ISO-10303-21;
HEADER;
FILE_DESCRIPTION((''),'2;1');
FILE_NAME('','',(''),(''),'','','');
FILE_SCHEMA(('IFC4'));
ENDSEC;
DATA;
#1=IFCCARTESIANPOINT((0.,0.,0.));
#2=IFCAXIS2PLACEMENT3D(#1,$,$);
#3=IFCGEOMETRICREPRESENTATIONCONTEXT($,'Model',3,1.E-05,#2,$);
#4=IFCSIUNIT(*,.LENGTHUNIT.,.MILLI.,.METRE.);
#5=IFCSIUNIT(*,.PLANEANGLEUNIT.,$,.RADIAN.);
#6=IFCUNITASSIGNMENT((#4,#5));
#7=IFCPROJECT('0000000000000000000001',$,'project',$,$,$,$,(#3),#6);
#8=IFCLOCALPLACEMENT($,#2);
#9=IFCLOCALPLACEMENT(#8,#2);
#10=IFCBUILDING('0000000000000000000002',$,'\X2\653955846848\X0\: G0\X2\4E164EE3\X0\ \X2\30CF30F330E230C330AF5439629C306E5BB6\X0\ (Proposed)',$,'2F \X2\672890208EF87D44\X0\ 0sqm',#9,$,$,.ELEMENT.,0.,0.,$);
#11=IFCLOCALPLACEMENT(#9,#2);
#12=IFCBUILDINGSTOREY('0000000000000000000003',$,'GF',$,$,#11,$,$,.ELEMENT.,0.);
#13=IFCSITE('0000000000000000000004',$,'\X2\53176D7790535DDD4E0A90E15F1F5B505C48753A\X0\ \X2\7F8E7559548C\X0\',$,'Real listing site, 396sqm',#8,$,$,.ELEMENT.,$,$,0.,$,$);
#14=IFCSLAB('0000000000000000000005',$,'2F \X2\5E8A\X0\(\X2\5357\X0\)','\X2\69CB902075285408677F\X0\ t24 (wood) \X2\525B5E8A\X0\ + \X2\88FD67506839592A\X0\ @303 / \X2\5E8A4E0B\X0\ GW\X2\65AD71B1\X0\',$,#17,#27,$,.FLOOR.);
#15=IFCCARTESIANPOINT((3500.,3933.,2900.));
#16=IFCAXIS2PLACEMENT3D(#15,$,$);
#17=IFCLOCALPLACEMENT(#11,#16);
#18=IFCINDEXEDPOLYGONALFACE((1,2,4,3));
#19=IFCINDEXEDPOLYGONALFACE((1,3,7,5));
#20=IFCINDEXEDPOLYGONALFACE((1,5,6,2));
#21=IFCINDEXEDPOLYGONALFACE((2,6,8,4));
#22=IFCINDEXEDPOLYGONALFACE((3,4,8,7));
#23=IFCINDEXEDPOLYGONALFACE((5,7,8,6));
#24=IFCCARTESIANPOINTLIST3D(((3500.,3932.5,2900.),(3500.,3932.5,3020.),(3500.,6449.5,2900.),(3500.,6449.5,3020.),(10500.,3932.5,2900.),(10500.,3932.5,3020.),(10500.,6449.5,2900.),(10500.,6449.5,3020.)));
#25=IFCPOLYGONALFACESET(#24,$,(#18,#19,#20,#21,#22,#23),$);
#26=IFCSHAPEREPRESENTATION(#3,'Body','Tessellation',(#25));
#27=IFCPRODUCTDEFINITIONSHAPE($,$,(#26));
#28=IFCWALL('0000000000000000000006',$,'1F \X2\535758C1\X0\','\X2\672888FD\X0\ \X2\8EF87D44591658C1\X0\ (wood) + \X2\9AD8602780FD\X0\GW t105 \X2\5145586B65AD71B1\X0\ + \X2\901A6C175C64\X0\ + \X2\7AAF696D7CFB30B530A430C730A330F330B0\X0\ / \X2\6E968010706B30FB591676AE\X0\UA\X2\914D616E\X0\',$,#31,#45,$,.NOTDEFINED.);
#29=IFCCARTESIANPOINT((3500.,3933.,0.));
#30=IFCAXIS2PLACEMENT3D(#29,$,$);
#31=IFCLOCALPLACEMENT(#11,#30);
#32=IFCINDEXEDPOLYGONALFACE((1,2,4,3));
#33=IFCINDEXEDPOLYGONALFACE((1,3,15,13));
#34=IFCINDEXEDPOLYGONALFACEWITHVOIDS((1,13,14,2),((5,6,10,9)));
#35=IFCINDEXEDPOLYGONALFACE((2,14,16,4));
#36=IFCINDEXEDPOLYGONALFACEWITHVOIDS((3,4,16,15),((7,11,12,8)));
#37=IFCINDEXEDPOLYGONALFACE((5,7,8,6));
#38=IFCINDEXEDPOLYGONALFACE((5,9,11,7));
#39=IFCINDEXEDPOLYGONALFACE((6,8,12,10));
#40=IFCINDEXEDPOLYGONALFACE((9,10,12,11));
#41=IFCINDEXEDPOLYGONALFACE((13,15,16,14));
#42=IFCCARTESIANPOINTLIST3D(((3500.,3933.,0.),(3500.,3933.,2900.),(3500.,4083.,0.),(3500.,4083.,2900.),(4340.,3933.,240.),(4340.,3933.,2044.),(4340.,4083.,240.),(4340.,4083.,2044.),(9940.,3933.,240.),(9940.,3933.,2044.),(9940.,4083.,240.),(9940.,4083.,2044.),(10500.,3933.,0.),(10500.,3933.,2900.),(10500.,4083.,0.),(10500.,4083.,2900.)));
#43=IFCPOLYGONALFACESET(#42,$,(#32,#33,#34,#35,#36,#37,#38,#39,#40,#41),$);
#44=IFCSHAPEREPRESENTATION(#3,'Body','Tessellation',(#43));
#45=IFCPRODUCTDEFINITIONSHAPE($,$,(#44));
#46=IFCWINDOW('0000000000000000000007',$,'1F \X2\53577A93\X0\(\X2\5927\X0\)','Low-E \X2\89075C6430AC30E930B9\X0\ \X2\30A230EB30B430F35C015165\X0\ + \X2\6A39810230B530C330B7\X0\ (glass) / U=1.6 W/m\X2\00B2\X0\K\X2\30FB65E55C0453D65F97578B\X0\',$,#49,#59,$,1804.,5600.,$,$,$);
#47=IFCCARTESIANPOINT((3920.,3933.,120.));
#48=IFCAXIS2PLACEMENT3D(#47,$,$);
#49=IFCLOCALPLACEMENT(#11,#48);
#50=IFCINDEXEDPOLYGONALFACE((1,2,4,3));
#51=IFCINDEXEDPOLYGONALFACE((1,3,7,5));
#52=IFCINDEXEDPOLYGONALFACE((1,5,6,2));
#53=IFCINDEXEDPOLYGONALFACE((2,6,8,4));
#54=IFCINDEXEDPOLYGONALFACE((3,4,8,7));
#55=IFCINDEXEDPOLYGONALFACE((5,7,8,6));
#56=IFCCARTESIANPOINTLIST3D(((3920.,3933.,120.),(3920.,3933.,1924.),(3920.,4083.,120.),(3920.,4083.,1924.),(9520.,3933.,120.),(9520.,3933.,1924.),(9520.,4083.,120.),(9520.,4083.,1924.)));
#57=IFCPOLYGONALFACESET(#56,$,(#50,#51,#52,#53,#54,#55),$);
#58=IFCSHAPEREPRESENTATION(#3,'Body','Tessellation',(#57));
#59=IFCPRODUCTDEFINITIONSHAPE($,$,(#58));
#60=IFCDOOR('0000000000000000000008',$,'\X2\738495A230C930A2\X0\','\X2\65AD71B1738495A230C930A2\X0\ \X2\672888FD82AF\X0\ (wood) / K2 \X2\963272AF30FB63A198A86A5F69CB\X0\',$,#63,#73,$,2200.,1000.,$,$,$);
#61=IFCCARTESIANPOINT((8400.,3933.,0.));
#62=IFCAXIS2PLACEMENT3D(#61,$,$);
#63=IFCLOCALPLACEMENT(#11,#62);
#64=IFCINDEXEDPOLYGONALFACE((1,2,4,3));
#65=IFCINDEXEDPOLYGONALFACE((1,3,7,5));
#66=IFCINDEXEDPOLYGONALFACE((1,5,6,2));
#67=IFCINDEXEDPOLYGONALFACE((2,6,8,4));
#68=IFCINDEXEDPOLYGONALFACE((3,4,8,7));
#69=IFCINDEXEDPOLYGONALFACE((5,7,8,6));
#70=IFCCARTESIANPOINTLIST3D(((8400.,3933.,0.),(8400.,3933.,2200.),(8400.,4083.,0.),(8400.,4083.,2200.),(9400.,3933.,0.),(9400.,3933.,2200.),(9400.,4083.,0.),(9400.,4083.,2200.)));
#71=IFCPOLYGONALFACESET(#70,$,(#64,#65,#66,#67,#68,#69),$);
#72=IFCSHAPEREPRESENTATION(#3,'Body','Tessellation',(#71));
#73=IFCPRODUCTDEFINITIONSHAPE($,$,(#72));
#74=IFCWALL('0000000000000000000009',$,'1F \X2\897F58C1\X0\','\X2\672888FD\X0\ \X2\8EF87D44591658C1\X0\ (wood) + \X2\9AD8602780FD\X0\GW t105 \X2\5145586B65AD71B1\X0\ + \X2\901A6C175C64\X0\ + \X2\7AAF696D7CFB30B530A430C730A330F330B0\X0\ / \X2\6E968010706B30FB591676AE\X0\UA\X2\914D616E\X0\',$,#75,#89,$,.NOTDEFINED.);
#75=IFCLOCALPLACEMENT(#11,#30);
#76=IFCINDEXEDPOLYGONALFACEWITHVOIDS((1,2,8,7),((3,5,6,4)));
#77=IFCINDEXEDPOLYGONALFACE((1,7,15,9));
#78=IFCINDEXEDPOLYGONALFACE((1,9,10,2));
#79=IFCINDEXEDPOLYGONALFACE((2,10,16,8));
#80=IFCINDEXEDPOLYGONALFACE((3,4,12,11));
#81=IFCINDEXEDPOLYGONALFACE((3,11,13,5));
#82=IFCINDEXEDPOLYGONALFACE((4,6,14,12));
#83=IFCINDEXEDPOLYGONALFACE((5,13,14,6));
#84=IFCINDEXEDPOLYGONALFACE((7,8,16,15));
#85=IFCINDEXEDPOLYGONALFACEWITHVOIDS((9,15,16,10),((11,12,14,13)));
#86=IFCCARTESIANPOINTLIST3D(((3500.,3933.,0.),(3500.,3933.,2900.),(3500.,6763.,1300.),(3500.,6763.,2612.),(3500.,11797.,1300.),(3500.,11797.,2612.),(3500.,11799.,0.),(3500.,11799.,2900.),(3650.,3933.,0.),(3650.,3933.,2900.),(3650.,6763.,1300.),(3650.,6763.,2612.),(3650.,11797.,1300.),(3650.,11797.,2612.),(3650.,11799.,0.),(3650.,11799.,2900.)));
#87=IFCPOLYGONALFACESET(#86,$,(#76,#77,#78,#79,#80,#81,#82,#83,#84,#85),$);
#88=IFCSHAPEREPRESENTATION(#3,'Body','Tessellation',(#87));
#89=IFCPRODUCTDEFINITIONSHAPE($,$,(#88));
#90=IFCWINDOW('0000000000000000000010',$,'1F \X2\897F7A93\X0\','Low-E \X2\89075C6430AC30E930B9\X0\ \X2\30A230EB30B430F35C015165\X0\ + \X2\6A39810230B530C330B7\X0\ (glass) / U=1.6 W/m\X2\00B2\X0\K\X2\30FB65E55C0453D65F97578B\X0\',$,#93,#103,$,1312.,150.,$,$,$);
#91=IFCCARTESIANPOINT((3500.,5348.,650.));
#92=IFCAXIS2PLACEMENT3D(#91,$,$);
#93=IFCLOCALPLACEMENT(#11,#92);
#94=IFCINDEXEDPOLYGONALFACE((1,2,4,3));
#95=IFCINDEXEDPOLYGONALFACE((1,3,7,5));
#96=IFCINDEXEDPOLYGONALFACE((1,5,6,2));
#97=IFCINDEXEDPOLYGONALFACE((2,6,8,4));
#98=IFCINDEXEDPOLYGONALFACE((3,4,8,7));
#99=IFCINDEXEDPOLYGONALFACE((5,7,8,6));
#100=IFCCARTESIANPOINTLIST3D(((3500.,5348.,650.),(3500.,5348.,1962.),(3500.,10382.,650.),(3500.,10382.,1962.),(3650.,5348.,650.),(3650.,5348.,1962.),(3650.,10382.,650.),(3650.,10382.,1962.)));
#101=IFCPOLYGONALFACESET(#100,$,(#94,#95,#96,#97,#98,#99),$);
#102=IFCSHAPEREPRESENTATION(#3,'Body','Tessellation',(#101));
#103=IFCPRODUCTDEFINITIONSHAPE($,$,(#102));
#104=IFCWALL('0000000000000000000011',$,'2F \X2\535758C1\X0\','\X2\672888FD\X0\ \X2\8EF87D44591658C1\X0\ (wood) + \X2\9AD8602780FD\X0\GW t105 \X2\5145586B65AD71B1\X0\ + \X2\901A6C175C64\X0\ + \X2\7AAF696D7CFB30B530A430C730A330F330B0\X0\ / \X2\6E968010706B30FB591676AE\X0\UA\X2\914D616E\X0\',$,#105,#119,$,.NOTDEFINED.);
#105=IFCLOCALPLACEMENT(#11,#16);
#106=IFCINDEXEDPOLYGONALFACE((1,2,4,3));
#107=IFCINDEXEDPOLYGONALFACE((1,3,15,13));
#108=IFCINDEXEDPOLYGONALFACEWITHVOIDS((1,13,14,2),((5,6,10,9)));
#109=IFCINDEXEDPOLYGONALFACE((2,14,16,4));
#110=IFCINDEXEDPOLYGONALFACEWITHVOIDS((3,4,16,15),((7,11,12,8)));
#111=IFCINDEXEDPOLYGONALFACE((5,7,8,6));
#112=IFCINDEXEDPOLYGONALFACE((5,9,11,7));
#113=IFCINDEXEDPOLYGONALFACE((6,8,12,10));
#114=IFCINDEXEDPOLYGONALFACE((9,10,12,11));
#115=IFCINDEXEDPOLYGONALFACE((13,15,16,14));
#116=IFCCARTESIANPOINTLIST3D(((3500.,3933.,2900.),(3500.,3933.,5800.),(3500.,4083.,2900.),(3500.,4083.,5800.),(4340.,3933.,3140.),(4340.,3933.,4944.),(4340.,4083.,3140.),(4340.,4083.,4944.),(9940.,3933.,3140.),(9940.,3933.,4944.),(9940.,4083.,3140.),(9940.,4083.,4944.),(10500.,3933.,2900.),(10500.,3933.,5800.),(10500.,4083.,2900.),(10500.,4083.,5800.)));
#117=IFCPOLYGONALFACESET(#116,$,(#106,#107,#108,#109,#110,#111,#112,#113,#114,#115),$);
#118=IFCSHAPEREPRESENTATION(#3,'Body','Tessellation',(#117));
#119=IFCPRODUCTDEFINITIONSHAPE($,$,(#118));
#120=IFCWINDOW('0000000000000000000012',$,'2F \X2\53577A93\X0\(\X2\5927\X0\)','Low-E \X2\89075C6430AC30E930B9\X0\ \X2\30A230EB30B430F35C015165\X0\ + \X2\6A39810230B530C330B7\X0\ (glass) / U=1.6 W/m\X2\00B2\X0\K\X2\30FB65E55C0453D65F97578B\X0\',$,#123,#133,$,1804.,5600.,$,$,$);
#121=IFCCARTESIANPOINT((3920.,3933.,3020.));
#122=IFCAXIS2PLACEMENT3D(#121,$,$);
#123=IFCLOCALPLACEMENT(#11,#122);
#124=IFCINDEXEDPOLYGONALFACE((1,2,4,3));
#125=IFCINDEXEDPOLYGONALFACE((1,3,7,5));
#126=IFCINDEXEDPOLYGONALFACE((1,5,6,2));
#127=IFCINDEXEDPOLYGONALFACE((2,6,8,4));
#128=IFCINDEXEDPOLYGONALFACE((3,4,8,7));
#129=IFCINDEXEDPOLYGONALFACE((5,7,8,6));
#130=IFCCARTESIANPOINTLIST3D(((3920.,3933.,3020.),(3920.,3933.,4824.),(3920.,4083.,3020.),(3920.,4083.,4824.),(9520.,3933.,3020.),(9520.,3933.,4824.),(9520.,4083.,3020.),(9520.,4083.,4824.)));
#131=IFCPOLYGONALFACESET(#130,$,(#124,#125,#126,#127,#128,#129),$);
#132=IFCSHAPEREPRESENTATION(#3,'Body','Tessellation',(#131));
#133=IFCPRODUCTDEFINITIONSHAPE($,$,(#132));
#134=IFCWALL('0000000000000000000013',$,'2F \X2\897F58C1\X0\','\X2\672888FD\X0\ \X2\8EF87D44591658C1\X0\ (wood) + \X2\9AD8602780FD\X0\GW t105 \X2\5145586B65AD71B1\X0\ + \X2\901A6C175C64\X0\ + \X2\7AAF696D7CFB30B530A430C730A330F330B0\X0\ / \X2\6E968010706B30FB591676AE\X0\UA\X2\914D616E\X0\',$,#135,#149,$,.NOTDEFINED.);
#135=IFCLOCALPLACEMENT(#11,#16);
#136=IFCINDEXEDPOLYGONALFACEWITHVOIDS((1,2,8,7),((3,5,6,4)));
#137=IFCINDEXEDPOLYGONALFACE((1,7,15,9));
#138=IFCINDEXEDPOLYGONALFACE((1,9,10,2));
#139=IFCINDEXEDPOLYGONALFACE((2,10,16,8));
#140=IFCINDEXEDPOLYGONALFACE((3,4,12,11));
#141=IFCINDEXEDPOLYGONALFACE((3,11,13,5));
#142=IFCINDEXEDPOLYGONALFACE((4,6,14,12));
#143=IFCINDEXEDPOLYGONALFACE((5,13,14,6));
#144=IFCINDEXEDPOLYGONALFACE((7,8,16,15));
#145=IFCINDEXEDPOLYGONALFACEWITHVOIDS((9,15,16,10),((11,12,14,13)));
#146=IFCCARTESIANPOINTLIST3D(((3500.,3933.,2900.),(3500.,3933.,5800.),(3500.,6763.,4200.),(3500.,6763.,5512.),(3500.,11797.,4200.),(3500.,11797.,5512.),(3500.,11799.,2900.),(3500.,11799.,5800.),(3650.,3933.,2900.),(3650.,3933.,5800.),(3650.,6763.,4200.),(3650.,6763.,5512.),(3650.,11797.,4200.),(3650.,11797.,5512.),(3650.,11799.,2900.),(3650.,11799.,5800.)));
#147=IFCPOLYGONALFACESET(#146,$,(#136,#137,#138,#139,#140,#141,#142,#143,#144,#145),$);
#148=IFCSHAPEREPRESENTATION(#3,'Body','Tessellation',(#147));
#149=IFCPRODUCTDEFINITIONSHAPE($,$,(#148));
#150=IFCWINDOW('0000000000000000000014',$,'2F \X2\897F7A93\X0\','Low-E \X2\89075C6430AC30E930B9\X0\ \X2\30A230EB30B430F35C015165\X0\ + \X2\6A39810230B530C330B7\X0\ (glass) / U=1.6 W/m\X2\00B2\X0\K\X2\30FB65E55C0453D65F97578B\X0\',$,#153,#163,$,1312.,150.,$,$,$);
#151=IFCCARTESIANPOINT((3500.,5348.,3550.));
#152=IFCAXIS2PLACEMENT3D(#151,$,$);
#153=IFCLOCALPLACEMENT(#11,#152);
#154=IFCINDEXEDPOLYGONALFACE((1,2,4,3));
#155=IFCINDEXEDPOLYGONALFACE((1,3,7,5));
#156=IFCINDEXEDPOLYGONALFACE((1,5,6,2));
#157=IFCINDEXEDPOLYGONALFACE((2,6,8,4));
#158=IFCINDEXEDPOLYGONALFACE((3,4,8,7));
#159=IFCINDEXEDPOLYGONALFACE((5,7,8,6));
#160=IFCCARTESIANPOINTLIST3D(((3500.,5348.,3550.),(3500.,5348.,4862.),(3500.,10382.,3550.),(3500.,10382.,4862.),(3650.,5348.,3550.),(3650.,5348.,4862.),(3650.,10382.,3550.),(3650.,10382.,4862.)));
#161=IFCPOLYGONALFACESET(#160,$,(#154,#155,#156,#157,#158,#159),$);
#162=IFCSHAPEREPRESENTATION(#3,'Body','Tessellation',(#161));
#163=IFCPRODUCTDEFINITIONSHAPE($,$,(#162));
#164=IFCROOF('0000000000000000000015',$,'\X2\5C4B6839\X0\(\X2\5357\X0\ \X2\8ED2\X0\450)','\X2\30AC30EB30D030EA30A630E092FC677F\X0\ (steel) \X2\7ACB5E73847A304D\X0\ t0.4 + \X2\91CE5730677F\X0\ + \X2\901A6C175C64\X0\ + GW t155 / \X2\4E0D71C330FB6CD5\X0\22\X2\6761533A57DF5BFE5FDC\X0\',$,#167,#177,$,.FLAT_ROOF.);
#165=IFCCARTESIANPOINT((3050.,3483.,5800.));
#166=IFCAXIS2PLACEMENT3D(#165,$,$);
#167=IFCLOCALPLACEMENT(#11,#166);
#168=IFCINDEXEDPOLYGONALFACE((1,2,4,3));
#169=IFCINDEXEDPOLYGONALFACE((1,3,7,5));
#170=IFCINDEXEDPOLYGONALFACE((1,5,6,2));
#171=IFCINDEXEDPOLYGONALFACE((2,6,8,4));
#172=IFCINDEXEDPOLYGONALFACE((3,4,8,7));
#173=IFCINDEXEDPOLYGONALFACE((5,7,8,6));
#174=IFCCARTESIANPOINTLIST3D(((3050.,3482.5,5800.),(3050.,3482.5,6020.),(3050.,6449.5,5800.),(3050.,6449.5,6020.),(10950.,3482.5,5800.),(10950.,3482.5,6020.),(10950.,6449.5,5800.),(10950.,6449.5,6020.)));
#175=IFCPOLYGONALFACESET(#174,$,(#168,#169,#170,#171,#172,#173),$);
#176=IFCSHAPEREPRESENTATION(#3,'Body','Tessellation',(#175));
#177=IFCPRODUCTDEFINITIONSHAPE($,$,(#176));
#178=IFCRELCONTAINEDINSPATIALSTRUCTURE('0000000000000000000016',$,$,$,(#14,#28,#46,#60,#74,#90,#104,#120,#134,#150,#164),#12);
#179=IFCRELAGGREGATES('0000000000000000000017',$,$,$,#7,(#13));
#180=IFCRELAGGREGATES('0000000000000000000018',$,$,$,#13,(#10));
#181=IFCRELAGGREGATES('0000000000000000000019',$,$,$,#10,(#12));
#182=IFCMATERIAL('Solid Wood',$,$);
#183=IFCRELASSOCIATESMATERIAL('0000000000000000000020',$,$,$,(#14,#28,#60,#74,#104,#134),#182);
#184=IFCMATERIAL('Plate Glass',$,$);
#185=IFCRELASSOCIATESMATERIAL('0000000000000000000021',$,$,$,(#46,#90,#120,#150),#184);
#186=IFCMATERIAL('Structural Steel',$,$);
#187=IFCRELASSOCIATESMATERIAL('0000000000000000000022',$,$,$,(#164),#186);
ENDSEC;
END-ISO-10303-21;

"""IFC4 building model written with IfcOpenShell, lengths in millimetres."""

from ifc_helpers import new_model, si_unit, frame, frame_2d, origin, place, context, project, spatial, rectangle, extrude, material, element, fill, save


model = new_model("IFC4")

# Units and contexts
model_context = context("Model", 3, precision=1e-05, world=origin())
ifc_project = project(units=[si_unit("LENGTHUNIT", "METRE", prefix="MILLI"), si_unit("PLANEANGLEUNIT", "RADIAN")], contexts=[model_context])

# Site, building, storey
site_placement = place(None, origin())
site = spatial("IfcSite", under=ifc_project, at=site_placement, Name="北海道川上郡弟子屈町 美留和", ObjectType="Real listing site, 396sqm", CompositionType="ELEMENT", RefElevation=0.0)
building_placement = place(site_placement, origin())
building = spatial("IfcBuilding", under=site, at=building_placement, Name="改善案: G0世代 ハンモック吹抜の家 (Proposed)", ObjectType="2F 木造軸組 0sqm", CompositionType="ELEMENT", ElevationOfRefHeight=0.0, ElevationOfTerrain=0.0)
storey_placement = place(building_placement, origin())
storey = spatial("IfcBuildingStorey", under=building, at=storey_placement, Name="GF", CompositionType="ELEMENT", Elevation=0.0)

# Slab
ifc_material_1 = material(Name="Solid Wood")
slab_1_placement = place(storey_placement, frame((3500.0, 3933.0, 2900.0)))
element("IfcSlab", 1, at=slab_1_placement, inside=storey, material=ifc_material_1, Name="2F 床(南)", Description="構造用合板 t24 (wood) 剛床 + 製材根太 @303 / 床下 GW断熱", PredefinedType="FLOOR", context=model_context, shape_type="SweptSolid", body=[
    extrude(rectangle(XDim=7000.0, YDim=2517.0, at=frame_2d((3500.0, 1258.0))), frame((3500.0, 3933.0, 2900.0)), (0.0, 0.0, 1.0), 120.0),
])

# Wall, openings, window, door
wall_1_placement = place(storey_placement, frame((3500.0, 3933.0, 0.0)))
wall_1 = element("IfcWall", 2, at=wall_1_placement, inside=storey, material=ifc_material_1, Name="1F 南壁", Description="木製 軸組外壁 (wood) + 高性能GW t105 充填断熱 + 通気層 + 窯業系サイディング / 準耐火・外皮UA配慮", PredefinedType="NOTDEFINED", context=model_context, shape_type="SweptSolid", body=[
    extrude(rectangle(XDim=7000.0, YDim=150.0, at=frame_2d((3500.0, 75.0))), frame((3500.0, 3933.0, 0.0)), (0.0, 0.0, 1.0), 2900.0),
])
opening_1_placement = place(storey_placement, frame((3920.0, 3933.0, 120.0)))
opening_1 = element("IfcOpeningElement", 3, at=opening_1_placement, cuts=wall_1, PredefinedType="NOTDEFINED", context=model_context, shape_type="SweptSolid", body=[
    extrude(rectangle(XDim=5600.0, YDim=150.0, at=frame_2d((2800.0, 75.0))), frame((3920.0, 3933.0, 120.0)), (0.0, 0.0, 1.0), 1804.0),
])
opening_2_placement = place(storey_placement, frame((8400.0, 3933.0, 0.0)))
opening_2 = element("IfcOpeningElement", 4, at=opening_2_placement, cuts=wall_1, PredefinedType="NOTDEFINED", context=model_context, shape_type="SweptSolid", body=[
    extrude(rectangle(XDim=1000.0, YDim=150.0, at=frame_2d((500.0, 75.0))), frame((8400.0, 3933.0, 0.0)), (0.0, 0.0, 1.0), 2200.0),
])
ifc_material_2 = material(Name="Plate Glass")
window_1_placement = place(storey_placement, frame((3920.0, 3933.0, 120.0)))
window_1 = element("IfcWindow", 5, at=window_1_placement, inside=storey, material=ifc_material_2, Name="1F 南窓(大)", Description="Low-E 複層ガラス アルゴン封入 + 樹脂サッシ (glass) / U=1.6 W/m²K・日射取得型", OverallHeight=1804.0, OverallWidth=5600.0, context=model_context, shape_type="SweptSolid", body=[
    extrude(rectangle(XDim=5600.0, YDim=150.0, at=frame_2d((2800.0, 75.0))), frame((3920.0, 3933.0, 120.0)), (0.0, 0.0, 1.0), 1804.0),
])
fill(opening_1, window_1)
door_placement = place(storey_placement, frame((8400.0, 3933.0, 0.0)))
door = element("IfcDoor", 6, at=door_placement, inside=storey, material=ifc_material_1, Name="玄関ドア", Description="断熱玄関ドア 木製芯 (wood) / K2 防犯・採風機構", OverallHeight=2200.0, OverallWidth=1000.0, context=model_context, shape_type="SweptSolid", body=[
    extrude(rectangle(XDim=1000.0, YDim=150.0, at=frame_2d((500.0, 75.0))), frame((8400.0, 3933.0, 0.0)), (0.0, 0.0, 1.0), 2200.0),
])
fill(opening_2, door)

# Walls, openings, windows
wall_2_placement = place(storey_placement, frame((3500.0, 3933.0, 0.0)))
wall_2 = element("IfcWall", 7, at=wall_2_placement, inside=storey, material=ifc_material_1, Name="1F 西壁", Description="木製 軸組外壁 (wood) + 高性能GW t105 充填断熱 + 通気層 + 窯業系サイディング / 準耐火・外皮UA配慮", PredefinedType="NOTDEFINED", context=model_context, shape_type="SweptSolid", body=[
    extrude(rectangle(XDim=150.0, YDim=7866.0, at=frame_2d((75.0, 3933.0))), frame((3500.0, 3933.0, 0.0)), (0.0, 0.0, 1.0), 2900.0),
])
opening_3_placement = place(storey_placement, frame((3500.0, 5348.0, 650.0)))
opening_3 = element("IfcOpeningElement", 8, at=opening_3_placement, cuts=wall_2, PredefinedType="NOTDEFINED", context=model_context, shape_type="SweptSolid", body=[
    extrude(rectangle(XDim=150.0, YDim=5034.0, at=frame_2d((75.0, 2517.0))), frame((3500.0, 5348.0, 650.0)), (0.0, 0.0, 1.0), 1312.0),
])
window_2_placement = place(storey_placement, frame((3500.0, 5348.0, 650.0)))
window_2 = element("IfcWindow", 9, at=window_2_placement, inside=storey, material=ifc_material_2, Name="1F 西窓", Description="Low-E 複層ガラス アルゴン封入 + 樹脂サッシ (glass) / U=1.6 W/m²K・日射取得型", OverallHeight=1312.0, OverallWidth=150.0, context=model_context, shape_type="SweptSolid", body=[
    extrude(rectangle(XDim=150.0, YDim=5034.0, at=frame_2d((75.0, 2517.0))), frame((3500.0, 5348.0, 650.0)), (0.0, 0.0, 1.0), 1312.0),
])
fill(opening_3, window_2)
wall_3_placement = place(storey_placement, frame((3500.0, 3933.0, 2900.0)))
wall_3 = element("IfcWall", 10, at=wall_3_placement, inside=storey, material=ifc_material_1, Name="2F 南壁", Description="木製 軸組外壁 (wood) + 高性能GW t105 充填断熱 + 通気層 + 窯業系サイディング / 準耐火・外皮UA配慮", PredefinedType="NOTDEFINED", context=model_context, shape_type="SweptSolid", body=[
    extrude(rectangle(XDim=7000.0, YDim=150.0, at=frame_2d((3500.0, 75.0))), frame((3500.0, 3933.0, 2900.0)), (0.0, 0.0, 1.0), 2900.0),
])
opening_4_placement = place(storey_placement, frame((3920.0, 3933.0, 3020.0)))
opening_4 = element("IfcOpeningElement", 11, at=opening_4_placement, cuts=wall_3, PredefinedType="NOTDEFINED", context=model_context, shape_type="SweptSolid", body=[
    extrude(rectangle(XDim=5600.0, YDim=150.0, at=frame_2d((2800.0, 75.0))), frame((3920.0, 3933.0, 3020.0)), (0.0, 0.0, 1.0), 1804.0),
])
window_3_placement = place(storey_placement, frame((3920.0, 3933.0, 3020.0)))
window_3 = element("IfcWindow", 12, at=window_3_placement, inside=storey, material=ifc_material_2, Name="2F 南窓(大)", Description="Low-E 複層ガラス アルゴン封入 + 樹脂サッシ (glass) / U=1.6 W/m²K・日射取得型", OverallHeight=1804.0, OverallWidth=5600.0, context=model_context, shape_type="SweptSolid", body=[
    extrude(rectangle(XDim=5600.0, YDim=150.0, at=frame_2d((2800.0, 75.0))), frame((3920.0, 3933.0, 3020.0)), (0.0, 0.0, 1.0), 1804.0),
])
fill(opening_4, window_3)
wall_4_placement = place(storey_placement, frame((3500.0, 3933.0, 2900.0)))
wall_4 = element("IfcWall", 13, at=wall_4_placement, inside=storey, material=ifc_material_1, Name="2F 西壁", Description="木製 軸組外壁 (wood) + 高性能GW t105 充填断熱 + 通気層 + 窯業系サイディング / 準耐火・外皮UA配慮", PredefinedType="NOTDEFINED", context=model_context, shape_type="SweptSolid", body=[
    extrude(rectangle(XDim=150.0, YDim=7866.0, at=frame_2d((75.0, 3933.0))), frame((3500.0, 3933.0, 2900.0)), (0.0, 0.0, 1.0), 2900.0),
])
opening_5_placement = place(storey_placement, frame((3500.0, 5348.0, 3550.0)))
opening_5 = element("IfcOpeningElement", 14, at=opening_5_placement, cuts=wall_4, PredefinedType="NOTDEFINED", context=model_context, shape_type="SweptSolid", body=[
    extrude(rectangle(XDim=150.0, YDim=5034.0, at=frame_2d((75.0, 2517.0))), frame((3500.0, 5348.0, 3550.0)), (0.0, 0.0, 1.0), 1312.0),
])
window_4_placement = place(storey_placement, frame((3500.0, 5348.0, 3550.0)))
window_4 = element("IfcWindow", 15, at=window_4_placement, inside=storey, material=ifc_material_2, Name="2F 西窓", Description="Low-E 複層ガラス アルゴン封入 + 樹脂サッシ (glass) / U=1.6 W/m²K・日射取得型", OverallHeight=1312.0, OverallWidth=150.0, context=model_context, shape_type="SweptSolid", body=[
    extrude(rectangle(XDim=150.0, YDim=5034.0, at=frame_2d((75.0, 2517.0))), frame((3500.0, 5348.0, 3550.0)), (0.0, 0.0, 1.0), 1312.0),
])
fill(opening_5, window_4)

# Roof
ifc_material_3 = material(Name="Structural Steel")
roof_1_placement = place(storey_placement, frame((3050.0, 3483.0, 5800.0)))
element("IfcRoof", 16, at=roof_1_placement, inside=storey, material=ifc_material_3, Name="屋根(南 軒450)", Description="ガルバリウム鋼板 (steel) 立平葺き t0.4 + 野地板 + 通気層 + GW t155 / 不燃・法22条区域対応", PredefinedType="FLAT_ROOF", context=model_context, shape_type="SweptSolid", body=[
    extrude(rectangle(XDim=7900.0, YDim=2967.0, at=frame_2d((3950.0, 1483.0))), frame((3050.0, 3483.0, 5800.0)), (0.0, 0.0, 1.0), 220.0),
])

save(model, "model.ifc")
